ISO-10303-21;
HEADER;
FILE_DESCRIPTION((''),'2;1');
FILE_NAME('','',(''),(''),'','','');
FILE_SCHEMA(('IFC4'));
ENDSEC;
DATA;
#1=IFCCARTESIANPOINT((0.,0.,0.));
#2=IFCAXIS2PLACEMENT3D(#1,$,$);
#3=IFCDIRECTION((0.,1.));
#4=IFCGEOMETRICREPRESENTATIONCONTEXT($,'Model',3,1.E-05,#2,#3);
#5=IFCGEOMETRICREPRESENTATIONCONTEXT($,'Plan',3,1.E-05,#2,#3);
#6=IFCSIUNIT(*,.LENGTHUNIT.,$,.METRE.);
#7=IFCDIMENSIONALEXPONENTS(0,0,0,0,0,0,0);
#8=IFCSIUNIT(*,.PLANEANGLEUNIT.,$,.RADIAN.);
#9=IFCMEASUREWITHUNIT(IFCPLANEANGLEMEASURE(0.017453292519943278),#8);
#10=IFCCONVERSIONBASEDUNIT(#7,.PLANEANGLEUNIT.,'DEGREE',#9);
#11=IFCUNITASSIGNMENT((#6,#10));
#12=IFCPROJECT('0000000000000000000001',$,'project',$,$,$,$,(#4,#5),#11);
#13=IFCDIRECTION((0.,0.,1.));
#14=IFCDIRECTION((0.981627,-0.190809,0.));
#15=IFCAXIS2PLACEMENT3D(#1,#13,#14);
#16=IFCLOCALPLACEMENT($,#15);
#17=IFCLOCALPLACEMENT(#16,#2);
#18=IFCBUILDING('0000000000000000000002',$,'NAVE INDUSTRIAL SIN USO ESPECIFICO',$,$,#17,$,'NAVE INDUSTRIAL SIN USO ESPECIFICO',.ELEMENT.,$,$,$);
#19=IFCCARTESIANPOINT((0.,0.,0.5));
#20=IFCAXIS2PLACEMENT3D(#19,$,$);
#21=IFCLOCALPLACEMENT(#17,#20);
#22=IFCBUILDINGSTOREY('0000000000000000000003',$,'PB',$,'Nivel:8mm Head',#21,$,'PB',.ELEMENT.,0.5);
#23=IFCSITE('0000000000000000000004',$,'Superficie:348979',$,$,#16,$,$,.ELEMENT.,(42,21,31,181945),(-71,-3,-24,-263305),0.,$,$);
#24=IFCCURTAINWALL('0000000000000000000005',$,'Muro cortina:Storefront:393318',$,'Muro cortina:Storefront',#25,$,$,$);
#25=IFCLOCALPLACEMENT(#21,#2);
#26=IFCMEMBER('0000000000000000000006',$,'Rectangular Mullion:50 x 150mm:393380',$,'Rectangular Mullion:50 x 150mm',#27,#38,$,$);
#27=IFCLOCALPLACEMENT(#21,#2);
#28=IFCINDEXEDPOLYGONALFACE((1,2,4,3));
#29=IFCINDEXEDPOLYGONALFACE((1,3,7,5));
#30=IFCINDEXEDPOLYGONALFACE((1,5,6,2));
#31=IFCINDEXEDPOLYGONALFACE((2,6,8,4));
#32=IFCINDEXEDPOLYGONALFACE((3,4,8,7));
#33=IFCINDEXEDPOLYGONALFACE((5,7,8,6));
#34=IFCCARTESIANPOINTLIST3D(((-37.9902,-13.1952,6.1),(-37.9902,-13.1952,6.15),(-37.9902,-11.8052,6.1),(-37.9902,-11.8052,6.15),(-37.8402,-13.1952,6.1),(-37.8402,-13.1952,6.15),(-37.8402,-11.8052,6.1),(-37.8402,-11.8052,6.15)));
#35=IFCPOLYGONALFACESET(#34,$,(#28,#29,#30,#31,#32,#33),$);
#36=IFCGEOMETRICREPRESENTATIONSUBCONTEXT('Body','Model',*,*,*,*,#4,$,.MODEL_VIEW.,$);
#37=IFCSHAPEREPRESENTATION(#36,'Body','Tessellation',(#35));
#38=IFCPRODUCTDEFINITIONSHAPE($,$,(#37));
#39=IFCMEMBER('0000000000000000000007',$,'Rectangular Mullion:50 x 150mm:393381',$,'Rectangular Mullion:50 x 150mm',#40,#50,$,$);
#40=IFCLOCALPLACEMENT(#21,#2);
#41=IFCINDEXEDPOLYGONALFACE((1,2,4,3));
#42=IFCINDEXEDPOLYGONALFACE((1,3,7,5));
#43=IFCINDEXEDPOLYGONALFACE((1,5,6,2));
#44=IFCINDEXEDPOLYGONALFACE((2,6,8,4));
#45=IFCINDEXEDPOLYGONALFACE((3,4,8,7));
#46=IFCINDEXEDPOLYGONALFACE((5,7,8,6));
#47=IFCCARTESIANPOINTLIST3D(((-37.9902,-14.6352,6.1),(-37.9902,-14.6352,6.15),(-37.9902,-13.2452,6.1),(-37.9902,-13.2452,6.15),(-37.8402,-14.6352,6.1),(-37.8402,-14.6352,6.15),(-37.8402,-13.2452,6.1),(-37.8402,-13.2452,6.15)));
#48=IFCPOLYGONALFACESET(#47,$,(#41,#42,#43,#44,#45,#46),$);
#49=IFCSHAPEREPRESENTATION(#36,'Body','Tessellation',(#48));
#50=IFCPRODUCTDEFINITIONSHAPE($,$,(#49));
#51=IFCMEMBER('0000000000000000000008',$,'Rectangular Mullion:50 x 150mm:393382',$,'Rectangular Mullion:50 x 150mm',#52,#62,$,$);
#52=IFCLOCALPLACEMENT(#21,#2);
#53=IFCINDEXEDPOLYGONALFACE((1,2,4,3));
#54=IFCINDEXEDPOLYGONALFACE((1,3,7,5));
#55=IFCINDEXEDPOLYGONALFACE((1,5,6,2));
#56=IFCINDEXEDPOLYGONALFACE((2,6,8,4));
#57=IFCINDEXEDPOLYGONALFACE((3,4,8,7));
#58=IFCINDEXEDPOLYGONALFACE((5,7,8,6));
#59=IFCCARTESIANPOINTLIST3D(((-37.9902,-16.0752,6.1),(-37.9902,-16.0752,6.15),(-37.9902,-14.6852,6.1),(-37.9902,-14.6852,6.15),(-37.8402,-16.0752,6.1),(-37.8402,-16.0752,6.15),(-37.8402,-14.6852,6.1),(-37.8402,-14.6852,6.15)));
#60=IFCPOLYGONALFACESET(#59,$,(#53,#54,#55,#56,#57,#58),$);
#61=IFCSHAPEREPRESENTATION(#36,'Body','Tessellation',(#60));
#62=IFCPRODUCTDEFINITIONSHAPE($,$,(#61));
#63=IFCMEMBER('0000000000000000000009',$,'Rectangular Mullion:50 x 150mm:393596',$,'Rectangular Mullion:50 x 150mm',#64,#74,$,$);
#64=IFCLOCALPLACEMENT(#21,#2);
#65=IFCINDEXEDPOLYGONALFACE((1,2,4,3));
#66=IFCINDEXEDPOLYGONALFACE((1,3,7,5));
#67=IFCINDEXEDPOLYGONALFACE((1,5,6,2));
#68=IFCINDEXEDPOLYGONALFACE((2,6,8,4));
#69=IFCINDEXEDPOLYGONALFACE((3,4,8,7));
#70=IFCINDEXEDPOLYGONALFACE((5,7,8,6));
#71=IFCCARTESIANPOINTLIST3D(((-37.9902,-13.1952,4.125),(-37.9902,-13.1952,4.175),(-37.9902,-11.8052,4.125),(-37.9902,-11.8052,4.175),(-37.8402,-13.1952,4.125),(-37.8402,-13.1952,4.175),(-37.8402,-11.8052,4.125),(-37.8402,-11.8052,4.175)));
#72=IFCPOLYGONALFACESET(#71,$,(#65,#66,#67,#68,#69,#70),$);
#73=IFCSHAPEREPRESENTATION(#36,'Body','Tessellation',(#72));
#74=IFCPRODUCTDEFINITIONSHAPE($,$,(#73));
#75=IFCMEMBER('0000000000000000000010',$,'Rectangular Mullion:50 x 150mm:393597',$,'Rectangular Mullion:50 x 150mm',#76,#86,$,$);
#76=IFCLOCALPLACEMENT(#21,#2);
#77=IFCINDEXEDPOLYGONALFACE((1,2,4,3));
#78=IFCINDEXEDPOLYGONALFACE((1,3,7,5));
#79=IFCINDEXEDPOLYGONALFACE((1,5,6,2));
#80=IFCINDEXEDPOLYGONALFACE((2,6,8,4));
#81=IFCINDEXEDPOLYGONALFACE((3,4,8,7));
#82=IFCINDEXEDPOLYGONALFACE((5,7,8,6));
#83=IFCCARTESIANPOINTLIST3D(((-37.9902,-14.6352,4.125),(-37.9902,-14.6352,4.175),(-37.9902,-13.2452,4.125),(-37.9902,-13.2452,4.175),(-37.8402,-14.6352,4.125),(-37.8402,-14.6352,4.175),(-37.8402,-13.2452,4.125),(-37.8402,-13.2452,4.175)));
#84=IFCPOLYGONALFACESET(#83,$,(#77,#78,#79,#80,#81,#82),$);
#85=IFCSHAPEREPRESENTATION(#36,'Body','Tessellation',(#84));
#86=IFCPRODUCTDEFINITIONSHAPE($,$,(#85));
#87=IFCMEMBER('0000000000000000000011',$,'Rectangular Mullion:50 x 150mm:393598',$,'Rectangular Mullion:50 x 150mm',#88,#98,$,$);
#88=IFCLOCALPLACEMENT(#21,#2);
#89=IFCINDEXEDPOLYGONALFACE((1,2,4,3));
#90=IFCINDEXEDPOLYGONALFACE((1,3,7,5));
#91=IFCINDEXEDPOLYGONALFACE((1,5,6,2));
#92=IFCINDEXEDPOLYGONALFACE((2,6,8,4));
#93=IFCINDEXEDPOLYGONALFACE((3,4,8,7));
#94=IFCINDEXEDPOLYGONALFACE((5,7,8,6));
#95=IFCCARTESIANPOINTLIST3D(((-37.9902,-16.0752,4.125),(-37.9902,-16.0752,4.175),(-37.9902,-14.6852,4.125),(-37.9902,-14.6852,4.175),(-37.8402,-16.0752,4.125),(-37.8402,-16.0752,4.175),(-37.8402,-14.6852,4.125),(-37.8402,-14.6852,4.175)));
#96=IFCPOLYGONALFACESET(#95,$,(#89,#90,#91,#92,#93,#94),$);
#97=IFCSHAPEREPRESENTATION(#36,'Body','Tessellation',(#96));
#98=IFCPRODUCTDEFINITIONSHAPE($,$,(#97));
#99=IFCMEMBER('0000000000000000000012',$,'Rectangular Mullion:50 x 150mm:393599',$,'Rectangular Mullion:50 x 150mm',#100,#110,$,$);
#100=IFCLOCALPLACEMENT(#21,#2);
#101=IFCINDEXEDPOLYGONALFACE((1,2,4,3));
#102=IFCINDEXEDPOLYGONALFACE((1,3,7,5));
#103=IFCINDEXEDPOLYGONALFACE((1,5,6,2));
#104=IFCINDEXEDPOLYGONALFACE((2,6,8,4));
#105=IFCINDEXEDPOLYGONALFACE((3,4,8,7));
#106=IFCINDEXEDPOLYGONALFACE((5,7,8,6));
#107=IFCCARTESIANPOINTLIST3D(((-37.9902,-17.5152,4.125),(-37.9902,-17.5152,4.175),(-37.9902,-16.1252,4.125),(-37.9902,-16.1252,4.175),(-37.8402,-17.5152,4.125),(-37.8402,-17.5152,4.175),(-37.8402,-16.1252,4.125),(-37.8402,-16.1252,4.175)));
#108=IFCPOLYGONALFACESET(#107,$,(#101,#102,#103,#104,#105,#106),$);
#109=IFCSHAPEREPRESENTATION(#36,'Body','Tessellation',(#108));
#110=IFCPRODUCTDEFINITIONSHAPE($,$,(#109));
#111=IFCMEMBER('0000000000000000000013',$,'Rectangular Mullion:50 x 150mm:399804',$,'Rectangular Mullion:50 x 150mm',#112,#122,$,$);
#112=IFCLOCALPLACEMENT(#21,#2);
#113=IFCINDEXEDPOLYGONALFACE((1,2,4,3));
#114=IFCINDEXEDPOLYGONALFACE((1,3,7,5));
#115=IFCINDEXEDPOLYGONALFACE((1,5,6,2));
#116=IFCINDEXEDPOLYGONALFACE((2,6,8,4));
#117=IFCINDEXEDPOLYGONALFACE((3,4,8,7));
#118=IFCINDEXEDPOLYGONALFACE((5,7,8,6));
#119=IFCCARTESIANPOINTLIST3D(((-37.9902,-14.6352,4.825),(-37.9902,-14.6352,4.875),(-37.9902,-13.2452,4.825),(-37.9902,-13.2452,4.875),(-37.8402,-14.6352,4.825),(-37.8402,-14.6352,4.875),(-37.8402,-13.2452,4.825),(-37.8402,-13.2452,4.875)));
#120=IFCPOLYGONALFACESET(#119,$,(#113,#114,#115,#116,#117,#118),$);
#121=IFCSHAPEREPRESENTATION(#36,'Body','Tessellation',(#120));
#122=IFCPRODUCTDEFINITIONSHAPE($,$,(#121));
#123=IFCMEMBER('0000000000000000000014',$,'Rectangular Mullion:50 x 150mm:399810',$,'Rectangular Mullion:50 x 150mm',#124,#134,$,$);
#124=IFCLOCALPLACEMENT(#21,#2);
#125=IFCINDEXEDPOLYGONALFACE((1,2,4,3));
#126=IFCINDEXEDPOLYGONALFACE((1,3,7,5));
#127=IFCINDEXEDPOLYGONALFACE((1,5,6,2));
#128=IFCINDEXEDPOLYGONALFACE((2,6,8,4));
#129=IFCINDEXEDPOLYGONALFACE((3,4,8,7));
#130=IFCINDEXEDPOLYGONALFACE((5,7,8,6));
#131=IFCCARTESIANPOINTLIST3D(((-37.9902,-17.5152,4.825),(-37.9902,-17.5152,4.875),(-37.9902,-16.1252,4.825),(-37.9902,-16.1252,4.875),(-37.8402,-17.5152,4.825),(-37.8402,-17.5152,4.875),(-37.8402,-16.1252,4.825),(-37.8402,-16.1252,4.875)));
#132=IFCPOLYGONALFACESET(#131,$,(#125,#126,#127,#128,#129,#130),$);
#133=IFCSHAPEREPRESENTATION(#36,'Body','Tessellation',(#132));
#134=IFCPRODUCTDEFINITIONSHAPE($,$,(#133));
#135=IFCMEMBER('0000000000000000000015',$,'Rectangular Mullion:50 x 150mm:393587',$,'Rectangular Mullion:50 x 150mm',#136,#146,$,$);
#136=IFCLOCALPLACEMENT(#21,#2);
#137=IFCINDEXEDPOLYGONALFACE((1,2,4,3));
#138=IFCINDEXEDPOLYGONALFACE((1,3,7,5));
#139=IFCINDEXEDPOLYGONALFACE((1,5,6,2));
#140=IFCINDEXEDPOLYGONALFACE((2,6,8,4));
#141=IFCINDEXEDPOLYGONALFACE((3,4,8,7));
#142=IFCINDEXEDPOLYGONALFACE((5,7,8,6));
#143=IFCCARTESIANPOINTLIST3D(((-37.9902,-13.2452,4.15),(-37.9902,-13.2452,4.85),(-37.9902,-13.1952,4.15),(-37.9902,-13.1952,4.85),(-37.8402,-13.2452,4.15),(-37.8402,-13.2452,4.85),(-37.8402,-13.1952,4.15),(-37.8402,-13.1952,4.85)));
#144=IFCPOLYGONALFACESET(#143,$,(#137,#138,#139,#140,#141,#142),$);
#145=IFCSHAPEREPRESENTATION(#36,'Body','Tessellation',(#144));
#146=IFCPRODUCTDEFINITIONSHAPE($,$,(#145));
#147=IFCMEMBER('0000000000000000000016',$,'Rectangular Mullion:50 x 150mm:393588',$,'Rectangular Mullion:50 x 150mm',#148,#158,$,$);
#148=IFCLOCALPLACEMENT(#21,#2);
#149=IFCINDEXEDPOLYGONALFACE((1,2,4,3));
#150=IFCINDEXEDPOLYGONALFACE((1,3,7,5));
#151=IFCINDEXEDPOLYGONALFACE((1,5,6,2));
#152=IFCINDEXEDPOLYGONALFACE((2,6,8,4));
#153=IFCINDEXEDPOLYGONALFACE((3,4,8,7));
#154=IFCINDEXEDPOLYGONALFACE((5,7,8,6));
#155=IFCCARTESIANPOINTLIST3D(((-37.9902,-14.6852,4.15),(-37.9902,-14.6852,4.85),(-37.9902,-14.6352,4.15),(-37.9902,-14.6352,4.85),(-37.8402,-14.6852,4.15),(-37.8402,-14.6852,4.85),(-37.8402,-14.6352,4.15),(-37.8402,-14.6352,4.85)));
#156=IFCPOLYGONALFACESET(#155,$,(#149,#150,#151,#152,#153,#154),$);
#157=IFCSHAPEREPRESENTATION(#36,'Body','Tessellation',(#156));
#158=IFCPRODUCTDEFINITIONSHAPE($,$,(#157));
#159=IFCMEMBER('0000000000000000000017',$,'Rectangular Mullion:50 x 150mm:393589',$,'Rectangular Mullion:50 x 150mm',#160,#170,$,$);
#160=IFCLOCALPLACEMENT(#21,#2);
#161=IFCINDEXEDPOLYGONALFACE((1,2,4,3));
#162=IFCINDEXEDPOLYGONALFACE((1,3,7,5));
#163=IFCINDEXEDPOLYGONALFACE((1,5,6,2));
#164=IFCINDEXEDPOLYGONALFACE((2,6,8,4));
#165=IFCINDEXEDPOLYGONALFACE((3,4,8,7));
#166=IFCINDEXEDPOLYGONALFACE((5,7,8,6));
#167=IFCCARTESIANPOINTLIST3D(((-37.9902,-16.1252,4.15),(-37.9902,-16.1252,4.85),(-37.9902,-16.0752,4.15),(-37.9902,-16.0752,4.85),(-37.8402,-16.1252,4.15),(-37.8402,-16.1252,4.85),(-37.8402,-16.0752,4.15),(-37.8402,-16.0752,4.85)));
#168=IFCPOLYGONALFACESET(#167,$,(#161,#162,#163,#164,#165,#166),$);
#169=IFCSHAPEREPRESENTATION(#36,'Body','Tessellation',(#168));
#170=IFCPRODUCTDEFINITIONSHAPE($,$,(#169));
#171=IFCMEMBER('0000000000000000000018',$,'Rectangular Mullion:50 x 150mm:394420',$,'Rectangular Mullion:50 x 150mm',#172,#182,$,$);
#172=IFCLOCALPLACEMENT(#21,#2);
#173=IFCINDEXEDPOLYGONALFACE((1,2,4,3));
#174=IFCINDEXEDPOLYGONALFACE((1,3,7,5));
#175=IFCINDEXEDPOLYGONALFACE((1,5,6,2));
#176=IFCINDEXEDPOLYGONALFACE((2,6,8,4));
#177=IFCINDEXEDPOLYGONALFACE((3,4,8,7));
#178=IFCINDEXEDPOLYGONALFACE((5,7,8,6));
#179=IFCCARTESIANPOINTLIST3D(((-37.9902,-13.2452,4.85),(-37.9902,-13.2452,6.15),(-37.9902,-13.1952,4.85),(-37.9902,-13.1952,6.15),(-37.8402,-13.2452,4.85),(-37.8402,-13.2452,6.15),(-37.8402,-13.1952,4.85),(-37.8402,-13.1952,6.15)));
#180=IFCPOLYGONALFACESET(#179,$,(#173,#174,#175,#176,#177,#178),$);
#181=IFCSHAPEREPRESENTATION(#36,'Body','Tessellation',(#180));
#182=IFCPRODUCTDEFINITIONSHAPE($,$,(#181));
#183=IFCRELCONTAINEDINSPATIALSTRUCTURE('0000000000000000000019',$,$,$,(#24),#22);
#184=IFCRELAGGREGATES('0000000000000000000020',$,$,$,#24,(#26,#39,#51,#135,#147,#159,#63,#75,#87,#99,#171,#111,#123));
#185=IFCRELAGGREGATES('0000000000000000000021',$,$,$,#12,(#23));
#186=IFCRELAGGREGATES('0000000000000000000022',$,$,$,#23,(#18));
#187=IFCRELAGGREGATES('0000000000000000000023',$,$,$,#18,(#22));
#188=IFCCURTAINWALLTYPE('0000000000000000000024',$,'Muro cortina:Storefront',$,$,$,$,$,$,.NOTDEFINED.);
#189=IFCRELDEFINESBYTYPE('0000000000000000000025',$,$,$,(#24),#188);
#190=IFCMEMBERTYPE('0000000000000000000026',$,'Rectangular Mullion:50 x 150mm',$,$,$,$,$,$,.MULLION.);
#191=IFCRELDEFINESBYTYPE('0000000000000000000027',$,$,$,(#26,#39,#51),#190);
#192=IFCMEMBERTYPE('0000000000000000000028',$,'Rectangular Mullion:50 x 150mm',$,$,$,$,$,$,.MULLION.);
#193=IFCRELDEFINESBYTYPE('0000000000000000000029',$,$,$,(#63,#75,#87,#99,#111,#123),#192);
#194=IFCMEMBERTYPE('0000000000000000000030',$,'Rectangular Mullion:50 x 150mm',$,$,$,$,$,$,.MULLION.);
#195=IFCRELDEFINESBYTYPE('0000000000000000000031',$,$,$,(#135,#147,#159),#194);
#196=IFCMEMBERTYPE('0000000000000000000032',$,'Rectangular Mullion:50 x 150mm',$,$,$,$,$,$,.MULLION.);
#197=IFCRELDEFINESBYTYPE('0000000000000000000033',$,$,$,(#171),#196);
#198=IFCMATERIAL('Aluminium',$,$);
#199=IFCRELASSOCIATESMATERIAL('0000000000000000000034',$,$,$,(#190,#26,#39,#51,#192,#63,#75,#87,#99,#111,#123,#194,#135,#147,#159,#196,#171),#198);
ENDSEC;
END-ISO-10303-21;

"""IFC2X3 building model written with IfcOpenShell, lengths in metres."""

from ifc_helpers import new_model, entity, si_unit, converted_unit, direction, frame, origin, origin_2d_with_axis, place, context, subcontext, project, spatial, rectangle, extrude, source, transform, mapped, material, type_object, type_shapes, element, aggregate, save


model = new_model("IFC2X3")

# Units and contexts
model_context = context("Model", 3, precision=1e-05, world=origin(), true_north=direction((0.0, 1.0)))
plan_context = context("Plan", 3, precision=1e-05, world=origin(), true_north=direction((0.0, 1.0)))
body_context = subcontext(model_context, "Body", "Model", "MODEL_VIEW")
ifc_project = project(units=[si_unit("LENGTHUNIT", "METRE"), converted_unit("PLANEANGLEUNIT", "DEGREE", entity("IfcPlaneAngleMeasure", 0.017453292519943278), si_unit("PLANEANGLEUNIT", "RADIAN"), dimensions=[0, 0, 0, 0, 0, 0, 0])], contexts=[model_context, plan_context])

# Site, building, storey
site_placement = place(None, frame((0.0, 0.0, 0.0), z_axis=(0.0, 0.0, 1.0), x_axis=(0.981627, -0.190809, 0.0)))
site = spatial("IfcSite", under=ifc_project, at=site_placement, Name="Superficie:348979", CompositionType="ELEMENT", RefLatitude=(42, 21, 31, 181945), RefLongitude=(-71, -3, -24, -263305), RefElevation=0.0)
building_placement = place(site_placement, origin())
building = spatial("IfcBuilding", under=site, at=building_placement, Name="NAVE INDUSTRIAL SIN USO ESPECIFICO", LongName="NAVE INDUSTRIAL SIN USO ESPECIFICO", CompositionType="ELEMENT")
storey_placement = place(building_placement, frame((0.0, 0.0, 0.5)))
storey = spatial("IfcBuildingStorey", under=building, at=storey_placement, Name="PB", ObjectType="Nivel:8mm Head", LongName="PB", CompositionType="ELEMENT", Elevation=0.5)

# Curtain wall, members
curtain_wall_type = type_object("IfcCurtainWallType", Name="Muro cortina:Storefront", PredefinedType="NOTDEFINED")
curtain_wall_placement = place(storey_placement, frame((0.0, 0.0, -0.5)))
curtain_wall = element("IfcCurtainWall", 1, at=curtain_wall_placement, inside=storey, type_object=curtain_wall_type, Name="Muro cortina:Storefront:393318", ObjectType="Muro cortina:Storefront")
ifc_material_1 = material(Name="Aluminium")
member_type_1 = type_object("IfcMemberType", Name="Rectangular Mullion:50 x 150mm", PredefinedType="MULLION", material=ifc_material_1)
shared_shape_1 = source(origin(), body_context, "Body", "SweptSolid", [
    extrude(rectangle(XDim=0.05, YDim=0.15, at=origin_2d_with_axis()), frame((-0.025, 0.0, -1.39), z_axis=(0.0, 0.0, 1.0), x_axis=(-1.0, 0.0, 0.0)), (0.0, 0.0, 1.0), 1.39),
])
type_shapes(member_type_1, [shared_shape_1])
member_1_placement = place(curtain_wall_placement, frame((-37.9152, -13.1952, 6.65), z_axis=(0.0, -1.0, 0.0), x_axis=(0.0, 0.0, 1.0)))
member_1 = element("IfcMember", 2, at=member_1_placement, type_object=member_type_1, material=ifc_material_1, Name="Rectangular Mullion:50 x 150mm:393380", ObjectType="Rectangular Mullion:50 x 150mm", context=body_context, shape_type="MappedRepresentation", body=[
    mapped(shared_shape_1, transform((0.0, 0.0, 0.0), scale=1.0)),
])
member_2_placement = place(curtain_wall_placement, frame((-37.9152, -14.6352, 6.65), z_axis=(0.0, -1.0, 0.0), x_axis=(0.0, 0.0, 1.0)))
member_2 = element("IfcMember", 3, at=member_2_placement, type_object=member_type_1, material=ifc_material_1, Name="Rectangular Mullion:50 x 150mm:393381", ObjectType="Rectangular Mullion:50 x 150mm", context=body_context, shape_type="MappedRepresentation", body=[
    mapped(shared_shape_1, transform((0.0, 0.0, 0.0), scale=1.0)),
])
member_3_placement = place(curtain_wall_placement, frame((-37.9152, -16.0752, 6.65), z_axis=(0.0, -1.0, 0.0), x_axis=(0.0, 0.0, 1.0)))
member_3 = element("IfcMember", 4, at=member_3_placement, type_object=member_type_1, material=ifc_material_1, Name="Rectangular Mullion:50 x 150mm:393382", ObjectType="Rectangular Mullion:50 x 150mm", context=body_context, shape_type="MappedRepresentation", body=[
    mapped(shared_shape_1, transform((0.0, 0.0, 0.0), scale=1.0)),
])
member_type_2 = type_object("IfcMemberType", Name="Rectangular Mullion:50 x 150mm", PredefinedType="MULLION", material=ifc_material_1)
shared_shape_2 = source(origin(), body_context, "Body", "SweptSolid", [
    extrude(rectangle(XDim=0.05, YDim=0.15, at=origin_2d_with_axis()), frame((0.0, 0.0, -1.39), z_axis=(0.0, 0.0, 1.0), x_axis=(-1.0, 0.0, 0.0)), (0.0, 0.0, 1.0), 1.39),
])
type_shapes(member_type_2, [shared_shape_2])
member_4_placement = place(curtain_wall_placement, frame((-37.9152, -13.1952, 4.65), z_axis=(0.0, -1.0, 0.0), x_axis=(0.0, 0.0, 1.0)))
member_4 = element("IfcMember", 5, at=member_4_placement, type_object=member_type_2, material=ifc_material_1, Name="Rectangular Mullion:50 x 150mm:393596", ObjectType="Rectangular Mullion:50 x 150mm", context=body_context, shape_type="MappedRepresentation", body=[
    mapped(shared_shape_2, transform((0.0, 0.0, 0.0), scale=1.0)),
])
member_5_placement = place(curtain_wall_placement, frame((-37.9152, -14.6352, 4.65), z_axis=(0.0, -1.0, 0.0), x_axis=(0.0, 0.0, 1.0)))
member_5 = element("IfcMember", 6, at=member_5_placement, type_object=member_type_2, material=ifc_material_1, Name="Rectangular Mullion:50 x 150mm:393597", ObjectType="Rectangular Mullion:50 x 150mm", context=body_context, shape_type="MappedRepresentation", body=[
    mapped(shared_shape_2, transform((0.0, 0.0, 0.0), scale=1.0)),
])
member_6_placement = place(curtain_wall_placement, frame((-37.9152, -16.0752, 4.65), z_axis=(0.0, -1.0, 0.0), x_axis=(0.0, 0.0, 1.0)))
member_6 = element("IfcMember", 7, at=member_6_placement, type_object=member_type_2, material=ifc_material_1, Name="Rectangular Mullion:50 x 150mm:393598", ObjectType="Rectangular Mullion:50 x 150mm", context=body_context, shape_type="MappedRepresentation", body=[
    mapped(shared_shape_2, transform((0.0, 0.0, 0.0), scale=1.0)),
])
member_7_placement = place(curtain_wall_placement, frame((-37.9152, -17.5152, 4.65), z_axis=(0.0, -1.0, 0.0), x_axis=(0.0, 0.0, 1.0)))
member_7 = element("IfcMember", 8, at=member_7_placement, type_object=member_type_2, material=ifc_material_1, Name="Rectangular Mullion:50 x 150mm:393599", ObjectType="Rectangular Mullion:50 x 150mm", context=body_context, shape_type="MappedRepresentation", body=[
    mapped(shared_shape_2, transform((0.0, 0.0, 0.0), scale=1.0)),
])
member_8_placement = place(curtain_wall_placement, frame((-37.9152, -14.6352, 5.35), z_axis=(0.0, -1.0, 0.0), x_axis=(0.0, 0.0, 1.0)))
member_8 = element("IfcMember", 9, at=member_8_placement, type_object=member_type_2, material=ifc_material_1, Name="Rectangular Mullion:50 x 150mm:399804", ObjectType="Rectangular Mullion:50 x 150mm", context=body_context, shape_type="MappedRepresentation", body=[
    mapped(shared_shape_2, transform((0.0, 0.0, 0.0), scale=1.0)),
])
member_9_placement = place(curtain_wall_placement, frame((-37.9152, -17.5152, 5.35), z_axis=(0.0, -1.0, 0.0), x_axis=(0.0, 0.0, 1.0)))
member_9 = element("IfcMember", 10, at=member_9_placement, type_object=member_type_2, material=ifc_material_1, Name="Rectangular Mullion:50 x 150mm:399810", ObjectType="Rectangular Mullion:50 x 150mm", context=body_context, shape_type="MappedRepresentation", body=[
    mapped(shared_shape_2, transform((0.0, 0.0, 0.0), scale=1.0)),
])
member_type_3 = type_object("IfcMemberType", Name="Rectangular Mullion:50 x 150mm", PredefinedType="MULLION", material=ifc_material_1)
shared_shape_3 = source(origin(), body_context, "Body", "SweptSolid", [
    extrude(rectangle(XDim=0.05, YDim=0.15, at=origin_2d_with_axis()), frame((0.0, 0.0, -0.7), z_axis=(0.0, 0.0, 1.0), x_axis=(-1.0, 0.0, 0.0)), (0.0, 0.0, 1.0), 0.7),
])
type_shapes(member_type_3, [shared_shape_3])
member_10_placement = place(curtain_wall_placement, frame((-37.9152, -13.2202, 4.65), z_axis=(0.0, 0.0, -1.0), x_axis=(0.0, -1.0, 0.0)))
member_10 = element("IfcMember", 11, at=member_10_placement, type_object=member_type_3, material=ifc_material_1, Name="Rectangular Mullion:50 x 150mm:393587", ObjectType="Rectangular Mullion:50 x 150mm", context=body_context, shape_type="MappedRepresentation", body=[
    mapped(shared_shape_3, transform((0.0, 0.0, 0.0), scale=1.0)),
])
member_11_placement = place(curtain_wall_placement, frame((-37.9152, -14.6602, 4.65), z_axis=(0.0, 0.0, -1.0), x_axis=(0.0, -1.0, 0.0)))
member_11 = element("IfcMember", 12, at=member_11_placement, type_object=member_type_3, material=ifc_material_1, Name="Rectangular Mullion:50 x 150mm:393588", ObjectType="Rectangular Mullion:50 x 150mm", context=body_context, shape_type="MappedRepresentation", body=[
    mapped(shared_shape_3, transform((0.0, 0.0, 0.0), scale=1.0)),
])
member_12_placement = place(curtain_wall_placement, frame((-37.9152, -16.1002, 4.65), z_axis=(0.0, 0.0, -1.0), x_axis=(0.0, -1.0, 0.0)))
member_12 = element("IfcMember", 13, at=member_12_placement, type_object=member_type_3, material=ifc_material_1, Name="Rectangular Mullion:50 x 150mm:393589", ObjectType="Rectangular Mullion:50 x 150mm", context=body_context, shape_type="MappedRepresentation", body=[
    mapped(shared_shape_3, transform((0.0, 0.0, 0.0), scale=1.0)),
])
member_type_4 = type_object("IfcMemberType", Name="Rectangular Mullion:50 x 150mm", PredefinedType="MULLION", material=ifc_material_1)
shared_shape_4 = source(origin(), body_context, "Body", "SweptSolid", [
    extrude(rectangle(XDim=0.05, YDim=0.15, at=origin_2d_with_axis()), frame((0.0, 0.0, -1.3), z_axis=(0.0, 0.0, 1.0), x_axis=(-1.0, 0.0, 0.0)), (0.0, 0.0, 1.0), 1.3),
])
type_shapes(member_type_4, [shared_shape_4])
member_13_placement = place(curtain_wall_placement, frame((-37.9152, -13.2202, 5.35), z_axis=(0.0, 0.0, -1.0), x_axis=(0.0, -1.0, 0.0)))
member_13 = element("IfcMember", 14, at=member_13_placement, type_object=member_type_4, material=ifc_material_1, Name="Rectangular Mullion:50 x 150mm:394420", ObjectType="Rectangular Mullion:50 x 150mm", context=body_context, shape_type="MappedRepresentation", body=[
    mapped(shared_shape_4, transform((0.0, 0.0, 0.0), scale=1.0)),
])
aggregate(curtain_wall, [member_1, member_2, member_3, member_10, member_11, member_12, member_4, member_5, member_6, member_7, member_13, member_8, member_9])

save(model, "model.ifc")
